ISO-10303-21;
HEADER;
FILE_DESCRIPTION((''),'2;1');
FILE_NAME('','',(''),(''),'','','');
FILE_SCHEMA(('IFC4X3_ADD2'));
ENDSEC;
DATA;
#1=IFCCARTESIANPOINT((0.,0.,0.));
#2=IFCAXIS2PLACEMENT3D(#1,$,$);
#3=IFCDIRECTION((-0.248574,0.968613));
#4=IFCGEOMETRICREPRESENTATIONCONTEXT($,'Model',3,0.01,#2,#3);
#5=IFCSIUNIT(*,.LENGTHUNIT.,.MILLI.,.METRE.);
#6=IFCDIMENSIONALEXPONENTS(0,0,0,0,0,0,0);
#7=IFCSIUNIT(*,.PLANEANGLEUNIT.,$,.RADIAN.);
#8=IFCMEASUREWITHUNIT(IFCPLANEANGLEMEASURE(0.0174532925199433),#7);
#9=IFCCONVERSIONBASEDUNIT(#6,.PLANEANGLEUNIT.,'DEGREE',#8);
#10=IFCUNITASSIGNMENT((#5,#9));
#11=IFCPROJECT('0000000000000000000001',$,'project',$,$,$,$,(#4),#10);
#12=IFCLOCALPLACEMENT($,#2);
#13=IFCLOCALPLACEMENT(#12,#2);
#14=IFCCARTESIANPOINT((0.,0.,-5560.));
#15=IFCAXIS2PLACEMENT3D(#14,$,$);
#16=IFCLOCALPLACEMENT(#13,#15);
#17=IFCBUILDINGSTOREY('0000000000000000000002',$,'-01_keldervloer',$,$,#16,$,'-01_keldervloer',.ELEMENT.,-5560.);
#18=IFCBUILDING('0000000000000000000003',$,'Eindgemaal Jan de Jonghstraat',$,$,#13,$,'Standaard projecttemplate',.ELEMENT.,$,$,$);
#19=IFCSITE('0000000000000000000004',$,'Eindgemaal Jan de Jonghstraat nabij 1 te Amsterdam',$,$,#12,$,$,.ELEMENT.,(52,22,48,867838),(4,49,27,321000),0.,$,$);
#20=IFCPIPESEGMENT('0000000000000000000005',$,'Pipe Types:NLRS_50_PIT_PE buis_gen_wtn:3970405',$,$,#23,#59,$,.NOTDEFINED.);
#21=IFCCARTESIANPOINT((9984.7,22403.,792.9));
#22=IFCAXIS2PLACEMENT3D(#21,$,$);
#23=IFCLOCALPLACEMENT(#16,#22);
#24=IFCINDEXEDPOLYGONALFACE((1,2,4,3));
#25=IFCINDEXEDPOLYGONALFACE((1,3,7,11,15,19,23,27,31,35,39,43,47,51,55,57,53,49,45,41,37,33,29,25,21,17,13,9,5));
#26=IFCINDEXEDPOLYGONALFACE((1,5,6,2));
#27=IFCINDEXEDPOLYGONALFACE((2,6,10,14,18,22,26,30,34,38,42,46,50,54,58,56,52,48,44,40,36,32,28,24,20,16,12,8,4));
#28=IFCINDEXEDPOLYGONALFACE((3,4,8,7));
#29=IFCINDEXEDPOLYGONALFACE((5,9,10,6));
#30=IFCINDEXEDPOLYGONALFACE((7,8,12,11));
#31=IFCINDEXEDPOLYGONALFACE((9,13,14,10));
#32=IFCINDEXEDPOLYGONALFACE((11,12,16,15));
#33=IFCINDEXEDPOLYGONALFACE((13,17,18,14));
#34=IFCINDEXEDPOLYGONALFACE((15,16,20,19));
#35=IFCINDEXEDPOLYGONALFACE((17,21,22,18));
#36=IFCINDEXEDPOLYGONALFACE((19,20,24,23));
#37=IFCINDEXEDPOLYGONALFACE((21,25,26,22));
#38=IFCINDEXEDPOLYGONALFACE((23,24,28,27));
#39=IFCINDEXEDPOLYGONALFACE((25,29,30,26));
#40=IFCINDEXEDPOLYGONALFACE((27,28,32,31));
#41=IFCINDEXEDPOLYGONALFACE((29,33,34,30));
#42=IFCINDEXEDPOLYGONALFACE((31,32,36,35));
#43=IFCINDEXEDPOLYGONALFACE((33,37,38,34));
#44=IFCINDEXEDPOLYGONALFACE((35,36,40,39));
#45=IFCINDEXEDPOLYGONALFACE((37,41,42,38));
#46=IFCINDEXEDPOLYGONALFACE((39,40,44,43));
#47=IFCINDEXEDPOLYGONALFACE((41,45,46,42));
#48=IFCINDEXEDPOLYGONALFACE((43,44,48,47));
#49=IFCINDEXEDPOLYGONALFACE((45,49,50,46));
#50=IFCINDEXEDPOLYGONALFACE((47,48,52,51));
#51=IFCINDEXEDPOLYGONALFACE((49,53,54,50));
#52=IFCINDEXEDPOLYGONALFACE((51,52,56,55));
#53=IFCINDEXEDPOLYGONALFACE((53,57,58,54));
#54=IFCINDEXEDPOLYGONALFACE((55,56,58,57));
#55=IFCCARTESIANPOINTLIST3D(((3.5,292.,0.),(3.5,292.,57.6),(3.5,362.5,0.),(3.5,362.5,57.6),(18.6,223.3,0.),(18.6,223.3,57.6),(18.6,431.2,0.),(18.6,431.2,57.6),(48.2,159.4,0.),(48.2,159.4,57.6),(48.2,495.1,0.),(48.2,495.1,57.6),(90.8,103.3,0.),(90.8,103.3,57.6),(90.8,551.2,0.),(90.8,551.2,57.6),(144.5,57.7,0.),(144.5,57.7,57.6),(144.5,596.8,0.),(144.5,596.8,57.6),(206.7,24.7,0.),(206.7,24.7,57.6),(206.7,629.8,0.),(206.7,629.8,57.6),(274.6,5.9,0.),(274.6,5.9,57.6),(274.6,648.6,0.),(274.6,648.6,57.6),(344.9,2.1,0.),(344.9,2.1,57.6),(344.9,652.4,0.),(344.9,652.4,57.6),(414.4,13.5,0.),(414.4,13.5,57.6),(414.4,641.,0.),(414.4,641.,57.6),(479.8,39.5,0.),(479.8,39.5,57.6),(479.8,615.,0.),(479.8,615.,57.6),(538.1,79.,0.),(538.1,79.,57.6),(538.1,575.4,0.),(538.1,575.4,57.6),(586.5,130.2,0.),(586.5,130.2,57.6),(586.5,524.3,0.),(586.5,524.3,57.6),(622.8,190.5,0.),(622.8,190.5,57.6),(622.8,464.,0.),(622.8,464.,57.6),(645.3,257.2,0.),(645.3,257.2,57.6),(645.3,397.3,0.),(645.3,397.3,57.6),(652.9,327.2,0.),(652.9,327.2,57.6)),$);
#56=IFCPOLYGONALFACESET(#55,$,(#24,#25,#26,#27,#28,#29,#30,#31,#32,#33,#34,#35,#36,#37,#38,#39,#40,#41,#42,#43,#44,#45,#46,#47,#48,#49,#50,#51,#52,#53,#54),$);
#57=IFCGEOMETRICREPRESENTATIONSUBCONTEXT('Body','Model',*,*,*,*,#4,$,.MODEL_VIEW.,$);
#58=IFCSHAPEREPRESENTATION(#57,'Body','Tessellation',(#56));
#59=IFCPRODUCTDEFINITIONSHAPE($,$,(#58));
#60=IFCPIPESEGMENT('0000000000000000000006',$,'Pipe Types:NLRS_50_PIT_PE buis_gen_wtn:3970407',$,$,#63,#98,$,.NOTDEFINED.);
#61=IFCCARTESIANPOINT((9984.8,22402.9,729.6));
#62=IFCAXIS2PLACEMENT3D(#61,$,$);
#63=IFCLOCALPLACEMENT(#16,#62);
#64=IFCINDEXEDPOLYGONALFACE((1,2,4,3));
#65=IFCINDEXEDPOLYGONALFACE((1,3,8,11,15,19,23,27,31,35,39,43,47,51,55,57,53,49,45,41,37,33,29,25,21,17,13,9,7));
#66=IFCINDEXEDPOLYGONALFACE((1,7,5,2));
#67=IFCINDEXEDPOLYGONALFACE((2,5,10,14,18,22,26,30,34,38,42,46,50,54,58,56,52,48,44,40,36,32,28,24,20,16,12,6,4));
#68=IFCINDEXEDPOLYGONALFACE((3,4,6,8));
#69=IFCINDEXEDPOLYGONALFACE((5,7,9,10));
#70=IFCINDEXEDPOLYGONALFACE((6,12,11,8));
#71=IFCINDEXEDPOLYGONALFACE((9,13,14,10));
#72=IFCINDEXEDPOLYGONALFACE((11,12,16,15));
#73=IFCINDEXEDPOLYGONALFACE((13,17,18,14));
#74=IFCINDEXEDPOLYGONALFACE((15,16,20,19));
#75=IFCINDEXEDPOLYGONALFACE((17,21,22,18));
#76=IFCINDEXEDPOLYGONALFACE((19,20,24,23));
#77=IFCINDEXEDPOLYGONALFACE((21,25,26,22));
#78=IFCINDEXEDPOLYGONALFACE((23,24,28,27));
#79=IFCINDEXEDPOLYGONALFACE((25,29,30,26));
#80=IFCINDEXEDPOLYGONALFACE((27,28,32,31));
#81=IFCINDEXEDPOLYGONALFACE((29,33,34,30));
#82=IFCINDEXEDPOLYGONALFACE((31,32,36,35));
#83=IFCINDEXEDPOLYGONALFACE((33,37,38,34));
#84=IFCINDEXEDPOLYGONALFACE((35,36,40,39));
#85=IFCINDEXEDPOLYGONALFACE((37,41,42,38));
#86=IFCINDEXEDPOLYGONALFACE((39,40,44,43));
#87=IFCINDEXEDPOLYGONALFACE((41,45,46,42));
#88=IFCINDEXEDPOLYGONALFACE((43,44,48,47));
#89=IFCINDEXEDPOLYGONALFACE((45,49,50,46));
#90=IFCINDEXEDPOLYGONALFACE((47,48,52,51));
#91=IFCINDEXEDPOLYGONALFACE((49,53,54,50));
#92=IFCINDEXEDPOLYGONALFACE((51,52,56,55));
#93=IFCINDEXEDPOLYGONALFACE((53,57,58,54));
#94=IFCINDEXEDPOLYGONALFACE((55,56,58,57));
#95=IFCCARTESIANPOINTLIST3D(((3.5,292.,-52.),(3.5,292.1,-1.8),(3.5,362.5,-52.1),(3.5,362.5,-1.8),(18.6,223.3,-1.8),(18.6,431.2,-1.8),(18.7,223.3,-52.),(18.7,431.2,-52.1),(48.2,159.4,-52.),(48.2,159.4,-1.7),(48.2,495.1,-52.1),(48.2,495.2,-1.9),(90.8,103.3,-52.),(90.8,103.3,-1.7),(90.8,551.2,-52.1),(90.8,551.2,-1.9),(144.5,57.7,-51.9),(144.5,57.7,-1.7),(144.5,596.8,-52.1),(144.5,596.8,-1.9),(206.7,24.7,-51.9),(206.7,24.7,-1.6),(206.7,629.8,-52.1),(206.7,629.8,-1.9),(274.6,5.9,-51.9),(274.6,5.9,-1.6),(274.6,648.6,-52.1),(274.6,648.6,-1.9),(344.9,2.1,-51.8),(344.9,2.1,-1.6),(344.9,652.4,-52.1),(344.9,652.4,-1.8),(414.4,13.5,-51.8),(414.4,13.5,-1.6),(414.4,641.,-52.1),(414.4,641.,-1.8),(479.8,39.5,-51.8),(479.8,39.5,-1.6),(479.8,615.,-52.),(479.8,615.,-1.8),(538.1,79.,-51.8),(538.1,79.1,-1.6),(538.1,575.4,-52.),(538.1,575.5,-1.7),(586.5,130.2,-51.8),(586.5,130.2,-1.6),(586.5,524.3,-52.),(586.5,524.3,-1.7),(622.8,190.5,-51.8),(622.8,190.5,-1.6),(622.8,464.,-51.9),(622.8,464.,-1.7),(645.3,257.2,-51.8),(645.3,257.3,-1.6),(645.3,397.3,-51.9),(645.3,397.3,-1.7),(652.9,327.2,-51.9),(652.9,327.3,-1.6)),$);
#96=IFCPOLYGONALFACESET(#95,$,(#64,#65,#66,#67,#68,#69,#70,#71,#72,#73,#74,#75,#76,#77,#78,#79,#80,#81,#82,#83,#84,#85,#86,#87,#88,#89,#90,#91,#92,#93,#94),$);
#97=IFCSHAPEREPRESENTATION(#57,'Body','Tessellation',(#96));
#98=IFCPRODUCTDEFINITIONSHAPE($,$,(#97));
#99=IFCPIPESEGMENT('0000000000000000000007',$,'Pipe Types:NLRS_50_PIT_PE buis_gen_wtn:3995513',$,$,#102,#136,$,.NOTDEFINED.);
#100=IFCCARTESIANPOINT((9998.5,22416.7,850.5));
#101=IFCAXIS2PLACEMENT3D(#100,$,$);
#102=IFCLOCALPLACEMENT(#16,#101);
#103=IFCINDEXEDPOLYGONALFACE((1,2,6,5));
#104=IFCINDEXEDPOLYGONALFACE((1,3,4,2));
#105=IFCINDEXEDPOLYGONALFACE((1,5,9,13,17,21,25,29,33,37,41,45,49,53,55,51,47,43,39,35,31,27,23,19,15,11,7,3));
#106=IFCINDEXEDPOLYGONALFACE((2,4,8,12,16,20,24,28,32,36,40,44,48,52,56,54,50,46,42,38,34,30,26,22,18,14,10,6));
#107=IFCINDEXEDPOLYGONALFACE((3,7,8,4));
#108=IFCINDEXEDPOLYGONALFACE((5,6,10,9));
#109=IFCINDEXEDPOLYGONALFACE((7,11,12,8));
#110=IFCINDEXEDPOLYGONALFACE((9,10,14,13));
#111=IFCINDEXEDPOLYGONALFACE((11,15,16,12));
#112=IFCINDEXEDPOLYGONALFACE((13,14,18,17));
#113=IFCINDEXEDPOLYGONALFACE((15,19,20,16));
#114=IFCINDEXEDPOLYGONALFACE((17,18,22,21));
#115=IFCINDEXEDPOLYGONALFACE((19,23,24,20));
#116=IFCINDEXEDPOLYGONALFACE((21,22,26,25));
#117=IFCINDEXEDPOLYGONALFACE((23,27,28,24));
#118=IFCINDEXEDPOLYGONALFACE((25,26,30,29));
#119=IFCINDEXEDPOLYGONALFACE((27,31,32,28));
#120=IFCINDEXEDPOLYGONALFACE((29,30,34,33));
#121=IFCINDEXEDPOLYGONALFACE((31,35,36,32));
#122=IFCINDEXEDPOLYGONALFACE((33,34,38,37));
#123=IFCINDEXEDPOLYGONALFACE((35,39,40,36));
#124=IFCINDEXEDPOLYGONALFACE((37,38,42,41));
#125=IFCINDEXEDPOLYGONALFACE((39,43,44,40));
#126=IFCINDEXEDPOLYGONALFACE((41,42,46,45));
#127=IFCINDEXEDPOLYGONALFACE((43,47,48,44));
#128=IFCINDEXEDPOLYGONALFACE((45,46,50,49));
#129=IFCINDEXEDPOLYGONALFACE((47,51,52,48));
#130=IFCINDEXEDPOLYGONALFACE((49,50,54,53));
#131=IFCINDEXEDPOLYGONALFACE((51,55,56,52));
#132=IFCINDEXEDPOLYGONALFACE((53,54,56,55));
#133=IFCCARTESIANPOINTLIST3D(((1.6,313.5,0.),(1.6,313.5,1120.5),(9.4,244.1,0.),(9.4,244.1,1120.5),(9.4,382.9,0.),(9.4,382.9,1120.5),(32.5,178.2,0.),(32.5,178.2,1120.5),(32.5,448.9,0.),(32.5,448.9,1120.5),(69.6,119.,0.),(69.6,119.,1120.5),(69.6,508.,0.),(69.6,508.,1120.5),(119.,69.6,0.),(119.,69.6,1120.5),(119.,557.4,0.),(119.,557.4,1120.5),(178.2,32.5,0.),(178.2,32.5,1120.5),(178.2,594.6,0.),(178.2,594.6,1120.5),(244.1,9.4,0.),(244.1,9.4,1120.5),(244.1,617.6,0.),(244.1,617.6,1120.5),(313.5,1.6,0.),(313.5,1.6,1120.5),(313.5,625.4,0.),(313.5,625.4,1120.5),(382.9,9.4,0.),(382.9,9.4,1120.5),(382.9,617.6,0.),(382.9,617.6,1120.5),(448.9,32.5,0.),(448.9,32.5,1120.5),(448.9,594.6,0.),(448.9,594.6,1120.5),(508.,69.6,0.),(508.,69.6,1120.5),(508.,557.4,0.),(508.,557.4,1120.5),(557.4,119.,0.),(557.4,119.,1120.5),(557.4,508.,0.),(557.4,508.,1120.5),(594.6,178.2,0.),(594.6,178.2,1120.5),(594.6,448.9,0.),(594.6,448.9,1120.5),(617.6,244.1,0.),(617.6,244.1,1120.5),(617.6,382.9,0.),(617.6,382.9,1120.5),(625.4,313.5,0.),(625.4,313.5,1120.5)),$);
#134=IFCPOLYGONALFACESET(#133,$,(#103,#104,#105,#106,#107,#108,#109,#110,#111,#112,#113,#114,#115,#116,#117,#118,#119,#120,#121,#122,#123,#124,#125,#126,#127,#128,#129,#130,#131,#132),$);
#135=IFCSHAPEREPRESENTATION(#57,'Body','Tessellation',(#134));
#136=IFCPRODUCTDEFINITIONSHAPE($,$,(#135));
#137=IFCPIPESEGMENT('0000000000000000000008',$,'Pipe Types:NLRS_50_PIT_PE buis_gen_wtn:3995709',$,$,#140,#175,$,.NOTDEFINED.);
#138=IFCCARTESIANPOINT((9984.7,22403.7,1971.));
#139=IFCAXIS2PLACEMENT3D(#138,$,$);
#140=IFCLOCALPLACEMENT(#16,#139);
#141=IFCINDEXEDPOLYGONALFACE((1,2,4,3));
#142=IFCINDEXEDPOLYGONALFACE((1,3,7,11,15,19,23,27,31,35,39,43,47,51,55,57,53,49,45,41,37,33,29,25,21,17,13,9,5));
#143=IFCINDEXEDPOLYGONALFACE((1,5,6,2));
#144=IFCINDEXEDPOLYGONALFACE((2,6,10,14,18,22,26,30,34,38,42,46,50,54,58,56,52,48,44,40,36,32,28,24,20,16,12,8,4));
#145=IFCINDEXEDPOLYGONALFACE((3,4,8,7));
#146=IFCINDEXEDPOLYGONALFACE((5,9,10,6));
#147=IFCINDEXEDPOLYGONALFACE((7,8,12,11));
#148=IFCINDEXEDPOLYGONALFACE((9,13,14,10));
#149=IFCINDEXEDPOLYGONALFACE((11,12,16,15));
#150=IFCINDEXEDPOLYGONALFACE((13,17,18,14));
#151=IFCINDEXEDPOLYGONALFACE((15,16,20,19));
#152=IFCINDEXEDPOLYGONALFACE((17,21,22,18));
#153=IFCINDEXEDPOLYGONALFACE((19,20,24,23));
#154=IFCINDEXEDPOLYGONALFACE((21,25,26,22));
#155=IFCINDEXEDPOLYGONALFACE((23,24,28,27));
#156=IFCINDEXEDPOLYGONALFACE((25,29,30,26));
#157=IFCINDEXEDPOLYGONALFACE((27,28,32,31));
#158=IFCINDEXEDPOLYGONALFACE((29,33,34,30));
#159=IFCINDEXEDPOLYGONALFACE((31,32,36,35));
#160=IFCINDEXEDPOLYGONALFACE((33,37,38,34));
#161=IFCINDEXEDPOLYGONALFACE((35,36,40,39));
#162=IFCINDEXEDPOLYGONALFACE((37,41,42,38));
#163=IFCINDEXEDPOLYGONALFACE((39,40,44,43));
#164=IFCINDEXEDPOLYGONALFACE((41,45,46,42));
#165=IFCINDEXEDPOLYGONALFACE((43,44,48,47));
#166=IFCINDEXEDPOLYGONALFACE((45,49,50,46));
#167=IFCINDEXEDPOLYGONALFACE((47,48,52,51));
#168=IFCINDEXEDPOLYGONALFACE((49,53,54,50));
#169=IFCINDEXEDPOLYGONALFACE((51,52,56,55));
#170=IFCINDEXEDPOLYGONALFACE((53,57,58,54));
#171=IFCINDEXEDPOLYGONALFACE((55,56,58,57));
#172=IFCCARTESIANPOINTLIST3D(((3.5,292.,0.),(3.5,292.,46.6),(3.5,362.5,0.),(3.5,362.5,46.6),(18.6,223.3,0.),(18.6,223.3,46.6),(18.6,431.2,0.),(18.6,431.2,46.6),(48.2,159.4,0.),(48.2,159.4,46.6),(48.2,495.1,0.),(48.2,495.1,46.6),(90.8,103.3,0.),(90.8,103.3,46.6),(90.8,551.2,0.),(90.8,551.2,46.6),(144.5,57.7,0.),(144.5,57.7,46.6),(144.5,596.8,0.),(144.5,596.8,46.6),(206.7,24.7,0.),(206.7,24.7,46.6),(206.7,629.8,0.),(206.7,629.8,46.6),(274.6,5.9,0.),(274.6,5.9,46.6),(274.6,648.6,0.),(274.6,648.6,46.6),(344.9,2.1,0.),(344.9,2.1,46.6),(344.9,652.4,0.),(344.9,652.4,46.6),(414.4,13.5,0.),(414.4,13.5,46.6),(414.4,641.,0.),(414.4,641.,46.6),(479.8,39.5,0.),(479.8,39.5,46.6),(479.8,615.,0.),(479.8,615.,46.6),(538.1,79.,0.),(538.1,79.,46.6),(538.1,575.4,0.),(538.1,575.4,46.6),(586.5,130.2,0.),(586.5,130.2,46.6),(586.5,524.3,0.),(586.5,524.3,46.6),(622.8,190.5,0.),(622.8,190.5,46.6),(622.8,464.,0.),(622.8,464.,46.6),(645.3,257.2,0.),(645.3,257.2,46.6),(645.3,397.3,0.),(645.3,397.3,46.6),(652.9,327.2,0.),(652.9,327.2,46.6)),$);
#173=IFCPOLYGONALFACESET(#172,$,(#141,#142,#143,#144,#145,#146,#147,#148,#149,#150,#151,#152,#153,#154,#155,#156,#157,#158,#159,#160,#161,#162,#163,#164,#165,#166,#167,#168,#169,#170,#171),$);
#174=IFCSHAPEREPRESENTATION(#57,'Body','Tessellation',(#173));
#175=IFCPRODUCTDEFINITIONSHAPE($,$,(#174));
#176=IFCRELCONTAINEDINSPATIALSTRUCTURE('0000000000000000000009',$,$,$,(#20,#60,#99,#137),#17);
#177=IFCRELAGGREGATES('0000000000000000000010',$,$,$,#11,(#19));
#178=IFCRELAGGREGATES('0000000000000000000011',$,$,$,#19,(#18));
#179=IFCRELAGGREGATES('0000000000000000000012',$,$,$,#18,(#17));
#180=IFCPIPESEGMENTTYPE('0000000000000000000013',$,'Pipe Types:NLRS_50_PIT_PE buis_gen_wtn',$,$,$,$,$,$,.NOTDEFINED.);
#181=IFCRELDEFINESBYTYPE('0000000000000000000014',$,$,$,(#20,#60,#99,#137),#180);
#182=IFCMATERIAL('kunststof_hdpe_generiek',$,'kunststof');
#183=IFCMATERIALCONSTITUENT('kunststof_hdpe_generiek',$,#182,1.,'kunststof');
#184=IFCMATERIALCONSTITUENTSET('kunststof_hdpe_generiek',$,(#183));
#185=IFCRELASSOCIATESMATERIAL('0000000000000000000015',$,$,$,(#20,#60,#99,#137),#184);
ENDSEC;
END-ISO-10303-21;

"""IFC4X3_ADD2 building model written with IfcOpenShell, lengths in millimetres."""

from ifc_helpers import new_model, entity, si_unit, converted_unit, direction, frame, frame_2d, origin, origin_2d_with_axis, place, context, subcontext, project, spatial, circle, extrude, material, constituent, constituent_set, type_object, element, save


model = new_model("IFC4X3_ADD2")

# Units and contexts
model_context = context("Model", 3, precision=0.01, world=origin(), true_north=direction((-0.248574, 0.968613)))
body_context = subcontext(model_context, "Body", "Model", "MODEL_VIEW")
ifc_project = project(units=[si_unit("LENGTHUNIT", "METRE", prefix="MILLI"), converted_unit("PLANEANGLEUNIT", "DEGREE", entity("IfcPlaneAngleMeasure", 0.0174532925199433), si_unit("PLANEANGLEUNIT", "RADIAN"), dimensions=[0, 0, 0, 0, 0, 0, 0])], contexts=[model_context])

# Site, building, storey
site_placement = place(None, origin())
site = spatial("IfcSite", under=ifc_project, at=site_placement, Name="Eindgemaal Jan de Jonghstraat nabij 1 te Amsterdam", CompositionType="ELEMENT", RefLatitude=(52, 22, 48, 867838), RefLongitude=(4, 49, 27, 321000), RefElevation=0.0)
building_placement = place(site_placement, origin())
building = spatial("IfcBuilding", under=site, at=building_placement, Name="Eindgemaal Jan de Jonghstraat", LongName="Standaard projecttemplate", CompositionType="ELEMENT")
storey_placement = place(building_placement, frame((0.0, 0.0, -5560.0)))
storey = spatial("IfcBuildingStorey", under=building, at=storey_placement, Name="-01_keldervloer", LongName="-01_keldervloer", CompositionType="ELEMENT", Elevation=-5560.0)

# Pipe segments
ifc_material_1 = material(Name="kunststof_hdpe_generiek", Category="kunststof")
ifc_constituent_1 = constituent(ifc_material_1, Name="kunststof_hdpe_generiek", Category="kunststof", fraction=1.0)
ifc_constituent_set_1 = constituent_set(constituents=[ifc_constituent_1], Name="kunststof_hdpe_generiek")
pipe_segment_type_1 = type_object("IfcPipeSegmentType", Name="Pipe Types:NLRS_50_PIT_PE buis_gen_wtn", PredefinedType="NOTDEFINED")
pipe_segment_1_placement = place(storey_placement, frame((9984.7, 22403.0, 792.9)))
element("IfcPipeSegment", 1, at=pipe_segment_1_placement, inside=storey, type_object=pipe_segment_type_1, material=ifc_constituent_set_1, Name="Pipe Types:NLRS_50_PIT_PE buis_gen_wtn:3970405", PredefinedType="NOTDEFINED", context=body_context, shape_type="SweptSolid", body=[
    extrude(circle(Radius=325.6, at=frame_2d((0.0, 0.0), x_axis=(1.0, 0.0))), frame((327.2, 327.2, 0.0)), (0.0, 0.0, 1.0), 57.6),
])
pipe_segment_2_placement = place(storey_placement, frame((9984.8, 22402.9, 729.6)))
element("IfcPipeSegment", 2, at=pipe_segment_2_placement, inside=storey, type_object=pipe_segment_type_1, material=ifc_constituent_set_1, Name="Pipe Types:NLRS_50_PIT_PE buis_gen_wtn:3970407", PredefinedType="NOTDEFINED", context=body_context, shape_type="SweptSolid", body=[
    extrude(circle(Radius=325.6, at=origin_2d_with_axis()), frame((327.3, 327.2, -52.0), z_axis=(-0.000291, 0.000376, 1.0), x_axis=(1.0, 0.0, 0.000291)), (0.0, 0.0, 1.0), 50.2),
])
pipe_segment_3_placement = place(storey_placement, frame((9998.5, 22416.7, 850.5)))
element("IfcPipeSegment", 3, at=pipe_segment_3_placement, inside=storey, type_object=pipe_segment_type_1, material=ifc_constituent_set_1, Name="Pipe Types:NLRS_50_PIT_PE buis_gen_wtn:3995513", PredefinedType="NOTDEFINED", context=body_context, shape_type="SweptSolid", body=[
    extrude(circle(Radius=311.9, at=origin_2d_with_axis()), frame((313.5, 313.5, 0.0)), (0.0, 0.0, 1.0), 1120.5),
])
pipe_segment_4_placement = place(storey_placement, frame((9984.7, 22403.7, 1971.0)))
element("IfcPipeSegment", 4, at=pipe_segment_4_placement, inside=storey, type_object=pipe_segment_type_1, material=ifc_constituent_set_1, Name="Pipe Types:NLRS_50_PIT_PE buis_gen_wtn:3995709", PredefinedType="NOTDEFINED", context=body_context, shape_type="SweptSolid", body=[
    extrude(circle(Radius=325.6, at=origin_2d_with_axis()), frame((327.2, 327.2, 0.0)), (0.0, 0.0, 1.0), 46.6),
])

save(model, "model.ifc")
